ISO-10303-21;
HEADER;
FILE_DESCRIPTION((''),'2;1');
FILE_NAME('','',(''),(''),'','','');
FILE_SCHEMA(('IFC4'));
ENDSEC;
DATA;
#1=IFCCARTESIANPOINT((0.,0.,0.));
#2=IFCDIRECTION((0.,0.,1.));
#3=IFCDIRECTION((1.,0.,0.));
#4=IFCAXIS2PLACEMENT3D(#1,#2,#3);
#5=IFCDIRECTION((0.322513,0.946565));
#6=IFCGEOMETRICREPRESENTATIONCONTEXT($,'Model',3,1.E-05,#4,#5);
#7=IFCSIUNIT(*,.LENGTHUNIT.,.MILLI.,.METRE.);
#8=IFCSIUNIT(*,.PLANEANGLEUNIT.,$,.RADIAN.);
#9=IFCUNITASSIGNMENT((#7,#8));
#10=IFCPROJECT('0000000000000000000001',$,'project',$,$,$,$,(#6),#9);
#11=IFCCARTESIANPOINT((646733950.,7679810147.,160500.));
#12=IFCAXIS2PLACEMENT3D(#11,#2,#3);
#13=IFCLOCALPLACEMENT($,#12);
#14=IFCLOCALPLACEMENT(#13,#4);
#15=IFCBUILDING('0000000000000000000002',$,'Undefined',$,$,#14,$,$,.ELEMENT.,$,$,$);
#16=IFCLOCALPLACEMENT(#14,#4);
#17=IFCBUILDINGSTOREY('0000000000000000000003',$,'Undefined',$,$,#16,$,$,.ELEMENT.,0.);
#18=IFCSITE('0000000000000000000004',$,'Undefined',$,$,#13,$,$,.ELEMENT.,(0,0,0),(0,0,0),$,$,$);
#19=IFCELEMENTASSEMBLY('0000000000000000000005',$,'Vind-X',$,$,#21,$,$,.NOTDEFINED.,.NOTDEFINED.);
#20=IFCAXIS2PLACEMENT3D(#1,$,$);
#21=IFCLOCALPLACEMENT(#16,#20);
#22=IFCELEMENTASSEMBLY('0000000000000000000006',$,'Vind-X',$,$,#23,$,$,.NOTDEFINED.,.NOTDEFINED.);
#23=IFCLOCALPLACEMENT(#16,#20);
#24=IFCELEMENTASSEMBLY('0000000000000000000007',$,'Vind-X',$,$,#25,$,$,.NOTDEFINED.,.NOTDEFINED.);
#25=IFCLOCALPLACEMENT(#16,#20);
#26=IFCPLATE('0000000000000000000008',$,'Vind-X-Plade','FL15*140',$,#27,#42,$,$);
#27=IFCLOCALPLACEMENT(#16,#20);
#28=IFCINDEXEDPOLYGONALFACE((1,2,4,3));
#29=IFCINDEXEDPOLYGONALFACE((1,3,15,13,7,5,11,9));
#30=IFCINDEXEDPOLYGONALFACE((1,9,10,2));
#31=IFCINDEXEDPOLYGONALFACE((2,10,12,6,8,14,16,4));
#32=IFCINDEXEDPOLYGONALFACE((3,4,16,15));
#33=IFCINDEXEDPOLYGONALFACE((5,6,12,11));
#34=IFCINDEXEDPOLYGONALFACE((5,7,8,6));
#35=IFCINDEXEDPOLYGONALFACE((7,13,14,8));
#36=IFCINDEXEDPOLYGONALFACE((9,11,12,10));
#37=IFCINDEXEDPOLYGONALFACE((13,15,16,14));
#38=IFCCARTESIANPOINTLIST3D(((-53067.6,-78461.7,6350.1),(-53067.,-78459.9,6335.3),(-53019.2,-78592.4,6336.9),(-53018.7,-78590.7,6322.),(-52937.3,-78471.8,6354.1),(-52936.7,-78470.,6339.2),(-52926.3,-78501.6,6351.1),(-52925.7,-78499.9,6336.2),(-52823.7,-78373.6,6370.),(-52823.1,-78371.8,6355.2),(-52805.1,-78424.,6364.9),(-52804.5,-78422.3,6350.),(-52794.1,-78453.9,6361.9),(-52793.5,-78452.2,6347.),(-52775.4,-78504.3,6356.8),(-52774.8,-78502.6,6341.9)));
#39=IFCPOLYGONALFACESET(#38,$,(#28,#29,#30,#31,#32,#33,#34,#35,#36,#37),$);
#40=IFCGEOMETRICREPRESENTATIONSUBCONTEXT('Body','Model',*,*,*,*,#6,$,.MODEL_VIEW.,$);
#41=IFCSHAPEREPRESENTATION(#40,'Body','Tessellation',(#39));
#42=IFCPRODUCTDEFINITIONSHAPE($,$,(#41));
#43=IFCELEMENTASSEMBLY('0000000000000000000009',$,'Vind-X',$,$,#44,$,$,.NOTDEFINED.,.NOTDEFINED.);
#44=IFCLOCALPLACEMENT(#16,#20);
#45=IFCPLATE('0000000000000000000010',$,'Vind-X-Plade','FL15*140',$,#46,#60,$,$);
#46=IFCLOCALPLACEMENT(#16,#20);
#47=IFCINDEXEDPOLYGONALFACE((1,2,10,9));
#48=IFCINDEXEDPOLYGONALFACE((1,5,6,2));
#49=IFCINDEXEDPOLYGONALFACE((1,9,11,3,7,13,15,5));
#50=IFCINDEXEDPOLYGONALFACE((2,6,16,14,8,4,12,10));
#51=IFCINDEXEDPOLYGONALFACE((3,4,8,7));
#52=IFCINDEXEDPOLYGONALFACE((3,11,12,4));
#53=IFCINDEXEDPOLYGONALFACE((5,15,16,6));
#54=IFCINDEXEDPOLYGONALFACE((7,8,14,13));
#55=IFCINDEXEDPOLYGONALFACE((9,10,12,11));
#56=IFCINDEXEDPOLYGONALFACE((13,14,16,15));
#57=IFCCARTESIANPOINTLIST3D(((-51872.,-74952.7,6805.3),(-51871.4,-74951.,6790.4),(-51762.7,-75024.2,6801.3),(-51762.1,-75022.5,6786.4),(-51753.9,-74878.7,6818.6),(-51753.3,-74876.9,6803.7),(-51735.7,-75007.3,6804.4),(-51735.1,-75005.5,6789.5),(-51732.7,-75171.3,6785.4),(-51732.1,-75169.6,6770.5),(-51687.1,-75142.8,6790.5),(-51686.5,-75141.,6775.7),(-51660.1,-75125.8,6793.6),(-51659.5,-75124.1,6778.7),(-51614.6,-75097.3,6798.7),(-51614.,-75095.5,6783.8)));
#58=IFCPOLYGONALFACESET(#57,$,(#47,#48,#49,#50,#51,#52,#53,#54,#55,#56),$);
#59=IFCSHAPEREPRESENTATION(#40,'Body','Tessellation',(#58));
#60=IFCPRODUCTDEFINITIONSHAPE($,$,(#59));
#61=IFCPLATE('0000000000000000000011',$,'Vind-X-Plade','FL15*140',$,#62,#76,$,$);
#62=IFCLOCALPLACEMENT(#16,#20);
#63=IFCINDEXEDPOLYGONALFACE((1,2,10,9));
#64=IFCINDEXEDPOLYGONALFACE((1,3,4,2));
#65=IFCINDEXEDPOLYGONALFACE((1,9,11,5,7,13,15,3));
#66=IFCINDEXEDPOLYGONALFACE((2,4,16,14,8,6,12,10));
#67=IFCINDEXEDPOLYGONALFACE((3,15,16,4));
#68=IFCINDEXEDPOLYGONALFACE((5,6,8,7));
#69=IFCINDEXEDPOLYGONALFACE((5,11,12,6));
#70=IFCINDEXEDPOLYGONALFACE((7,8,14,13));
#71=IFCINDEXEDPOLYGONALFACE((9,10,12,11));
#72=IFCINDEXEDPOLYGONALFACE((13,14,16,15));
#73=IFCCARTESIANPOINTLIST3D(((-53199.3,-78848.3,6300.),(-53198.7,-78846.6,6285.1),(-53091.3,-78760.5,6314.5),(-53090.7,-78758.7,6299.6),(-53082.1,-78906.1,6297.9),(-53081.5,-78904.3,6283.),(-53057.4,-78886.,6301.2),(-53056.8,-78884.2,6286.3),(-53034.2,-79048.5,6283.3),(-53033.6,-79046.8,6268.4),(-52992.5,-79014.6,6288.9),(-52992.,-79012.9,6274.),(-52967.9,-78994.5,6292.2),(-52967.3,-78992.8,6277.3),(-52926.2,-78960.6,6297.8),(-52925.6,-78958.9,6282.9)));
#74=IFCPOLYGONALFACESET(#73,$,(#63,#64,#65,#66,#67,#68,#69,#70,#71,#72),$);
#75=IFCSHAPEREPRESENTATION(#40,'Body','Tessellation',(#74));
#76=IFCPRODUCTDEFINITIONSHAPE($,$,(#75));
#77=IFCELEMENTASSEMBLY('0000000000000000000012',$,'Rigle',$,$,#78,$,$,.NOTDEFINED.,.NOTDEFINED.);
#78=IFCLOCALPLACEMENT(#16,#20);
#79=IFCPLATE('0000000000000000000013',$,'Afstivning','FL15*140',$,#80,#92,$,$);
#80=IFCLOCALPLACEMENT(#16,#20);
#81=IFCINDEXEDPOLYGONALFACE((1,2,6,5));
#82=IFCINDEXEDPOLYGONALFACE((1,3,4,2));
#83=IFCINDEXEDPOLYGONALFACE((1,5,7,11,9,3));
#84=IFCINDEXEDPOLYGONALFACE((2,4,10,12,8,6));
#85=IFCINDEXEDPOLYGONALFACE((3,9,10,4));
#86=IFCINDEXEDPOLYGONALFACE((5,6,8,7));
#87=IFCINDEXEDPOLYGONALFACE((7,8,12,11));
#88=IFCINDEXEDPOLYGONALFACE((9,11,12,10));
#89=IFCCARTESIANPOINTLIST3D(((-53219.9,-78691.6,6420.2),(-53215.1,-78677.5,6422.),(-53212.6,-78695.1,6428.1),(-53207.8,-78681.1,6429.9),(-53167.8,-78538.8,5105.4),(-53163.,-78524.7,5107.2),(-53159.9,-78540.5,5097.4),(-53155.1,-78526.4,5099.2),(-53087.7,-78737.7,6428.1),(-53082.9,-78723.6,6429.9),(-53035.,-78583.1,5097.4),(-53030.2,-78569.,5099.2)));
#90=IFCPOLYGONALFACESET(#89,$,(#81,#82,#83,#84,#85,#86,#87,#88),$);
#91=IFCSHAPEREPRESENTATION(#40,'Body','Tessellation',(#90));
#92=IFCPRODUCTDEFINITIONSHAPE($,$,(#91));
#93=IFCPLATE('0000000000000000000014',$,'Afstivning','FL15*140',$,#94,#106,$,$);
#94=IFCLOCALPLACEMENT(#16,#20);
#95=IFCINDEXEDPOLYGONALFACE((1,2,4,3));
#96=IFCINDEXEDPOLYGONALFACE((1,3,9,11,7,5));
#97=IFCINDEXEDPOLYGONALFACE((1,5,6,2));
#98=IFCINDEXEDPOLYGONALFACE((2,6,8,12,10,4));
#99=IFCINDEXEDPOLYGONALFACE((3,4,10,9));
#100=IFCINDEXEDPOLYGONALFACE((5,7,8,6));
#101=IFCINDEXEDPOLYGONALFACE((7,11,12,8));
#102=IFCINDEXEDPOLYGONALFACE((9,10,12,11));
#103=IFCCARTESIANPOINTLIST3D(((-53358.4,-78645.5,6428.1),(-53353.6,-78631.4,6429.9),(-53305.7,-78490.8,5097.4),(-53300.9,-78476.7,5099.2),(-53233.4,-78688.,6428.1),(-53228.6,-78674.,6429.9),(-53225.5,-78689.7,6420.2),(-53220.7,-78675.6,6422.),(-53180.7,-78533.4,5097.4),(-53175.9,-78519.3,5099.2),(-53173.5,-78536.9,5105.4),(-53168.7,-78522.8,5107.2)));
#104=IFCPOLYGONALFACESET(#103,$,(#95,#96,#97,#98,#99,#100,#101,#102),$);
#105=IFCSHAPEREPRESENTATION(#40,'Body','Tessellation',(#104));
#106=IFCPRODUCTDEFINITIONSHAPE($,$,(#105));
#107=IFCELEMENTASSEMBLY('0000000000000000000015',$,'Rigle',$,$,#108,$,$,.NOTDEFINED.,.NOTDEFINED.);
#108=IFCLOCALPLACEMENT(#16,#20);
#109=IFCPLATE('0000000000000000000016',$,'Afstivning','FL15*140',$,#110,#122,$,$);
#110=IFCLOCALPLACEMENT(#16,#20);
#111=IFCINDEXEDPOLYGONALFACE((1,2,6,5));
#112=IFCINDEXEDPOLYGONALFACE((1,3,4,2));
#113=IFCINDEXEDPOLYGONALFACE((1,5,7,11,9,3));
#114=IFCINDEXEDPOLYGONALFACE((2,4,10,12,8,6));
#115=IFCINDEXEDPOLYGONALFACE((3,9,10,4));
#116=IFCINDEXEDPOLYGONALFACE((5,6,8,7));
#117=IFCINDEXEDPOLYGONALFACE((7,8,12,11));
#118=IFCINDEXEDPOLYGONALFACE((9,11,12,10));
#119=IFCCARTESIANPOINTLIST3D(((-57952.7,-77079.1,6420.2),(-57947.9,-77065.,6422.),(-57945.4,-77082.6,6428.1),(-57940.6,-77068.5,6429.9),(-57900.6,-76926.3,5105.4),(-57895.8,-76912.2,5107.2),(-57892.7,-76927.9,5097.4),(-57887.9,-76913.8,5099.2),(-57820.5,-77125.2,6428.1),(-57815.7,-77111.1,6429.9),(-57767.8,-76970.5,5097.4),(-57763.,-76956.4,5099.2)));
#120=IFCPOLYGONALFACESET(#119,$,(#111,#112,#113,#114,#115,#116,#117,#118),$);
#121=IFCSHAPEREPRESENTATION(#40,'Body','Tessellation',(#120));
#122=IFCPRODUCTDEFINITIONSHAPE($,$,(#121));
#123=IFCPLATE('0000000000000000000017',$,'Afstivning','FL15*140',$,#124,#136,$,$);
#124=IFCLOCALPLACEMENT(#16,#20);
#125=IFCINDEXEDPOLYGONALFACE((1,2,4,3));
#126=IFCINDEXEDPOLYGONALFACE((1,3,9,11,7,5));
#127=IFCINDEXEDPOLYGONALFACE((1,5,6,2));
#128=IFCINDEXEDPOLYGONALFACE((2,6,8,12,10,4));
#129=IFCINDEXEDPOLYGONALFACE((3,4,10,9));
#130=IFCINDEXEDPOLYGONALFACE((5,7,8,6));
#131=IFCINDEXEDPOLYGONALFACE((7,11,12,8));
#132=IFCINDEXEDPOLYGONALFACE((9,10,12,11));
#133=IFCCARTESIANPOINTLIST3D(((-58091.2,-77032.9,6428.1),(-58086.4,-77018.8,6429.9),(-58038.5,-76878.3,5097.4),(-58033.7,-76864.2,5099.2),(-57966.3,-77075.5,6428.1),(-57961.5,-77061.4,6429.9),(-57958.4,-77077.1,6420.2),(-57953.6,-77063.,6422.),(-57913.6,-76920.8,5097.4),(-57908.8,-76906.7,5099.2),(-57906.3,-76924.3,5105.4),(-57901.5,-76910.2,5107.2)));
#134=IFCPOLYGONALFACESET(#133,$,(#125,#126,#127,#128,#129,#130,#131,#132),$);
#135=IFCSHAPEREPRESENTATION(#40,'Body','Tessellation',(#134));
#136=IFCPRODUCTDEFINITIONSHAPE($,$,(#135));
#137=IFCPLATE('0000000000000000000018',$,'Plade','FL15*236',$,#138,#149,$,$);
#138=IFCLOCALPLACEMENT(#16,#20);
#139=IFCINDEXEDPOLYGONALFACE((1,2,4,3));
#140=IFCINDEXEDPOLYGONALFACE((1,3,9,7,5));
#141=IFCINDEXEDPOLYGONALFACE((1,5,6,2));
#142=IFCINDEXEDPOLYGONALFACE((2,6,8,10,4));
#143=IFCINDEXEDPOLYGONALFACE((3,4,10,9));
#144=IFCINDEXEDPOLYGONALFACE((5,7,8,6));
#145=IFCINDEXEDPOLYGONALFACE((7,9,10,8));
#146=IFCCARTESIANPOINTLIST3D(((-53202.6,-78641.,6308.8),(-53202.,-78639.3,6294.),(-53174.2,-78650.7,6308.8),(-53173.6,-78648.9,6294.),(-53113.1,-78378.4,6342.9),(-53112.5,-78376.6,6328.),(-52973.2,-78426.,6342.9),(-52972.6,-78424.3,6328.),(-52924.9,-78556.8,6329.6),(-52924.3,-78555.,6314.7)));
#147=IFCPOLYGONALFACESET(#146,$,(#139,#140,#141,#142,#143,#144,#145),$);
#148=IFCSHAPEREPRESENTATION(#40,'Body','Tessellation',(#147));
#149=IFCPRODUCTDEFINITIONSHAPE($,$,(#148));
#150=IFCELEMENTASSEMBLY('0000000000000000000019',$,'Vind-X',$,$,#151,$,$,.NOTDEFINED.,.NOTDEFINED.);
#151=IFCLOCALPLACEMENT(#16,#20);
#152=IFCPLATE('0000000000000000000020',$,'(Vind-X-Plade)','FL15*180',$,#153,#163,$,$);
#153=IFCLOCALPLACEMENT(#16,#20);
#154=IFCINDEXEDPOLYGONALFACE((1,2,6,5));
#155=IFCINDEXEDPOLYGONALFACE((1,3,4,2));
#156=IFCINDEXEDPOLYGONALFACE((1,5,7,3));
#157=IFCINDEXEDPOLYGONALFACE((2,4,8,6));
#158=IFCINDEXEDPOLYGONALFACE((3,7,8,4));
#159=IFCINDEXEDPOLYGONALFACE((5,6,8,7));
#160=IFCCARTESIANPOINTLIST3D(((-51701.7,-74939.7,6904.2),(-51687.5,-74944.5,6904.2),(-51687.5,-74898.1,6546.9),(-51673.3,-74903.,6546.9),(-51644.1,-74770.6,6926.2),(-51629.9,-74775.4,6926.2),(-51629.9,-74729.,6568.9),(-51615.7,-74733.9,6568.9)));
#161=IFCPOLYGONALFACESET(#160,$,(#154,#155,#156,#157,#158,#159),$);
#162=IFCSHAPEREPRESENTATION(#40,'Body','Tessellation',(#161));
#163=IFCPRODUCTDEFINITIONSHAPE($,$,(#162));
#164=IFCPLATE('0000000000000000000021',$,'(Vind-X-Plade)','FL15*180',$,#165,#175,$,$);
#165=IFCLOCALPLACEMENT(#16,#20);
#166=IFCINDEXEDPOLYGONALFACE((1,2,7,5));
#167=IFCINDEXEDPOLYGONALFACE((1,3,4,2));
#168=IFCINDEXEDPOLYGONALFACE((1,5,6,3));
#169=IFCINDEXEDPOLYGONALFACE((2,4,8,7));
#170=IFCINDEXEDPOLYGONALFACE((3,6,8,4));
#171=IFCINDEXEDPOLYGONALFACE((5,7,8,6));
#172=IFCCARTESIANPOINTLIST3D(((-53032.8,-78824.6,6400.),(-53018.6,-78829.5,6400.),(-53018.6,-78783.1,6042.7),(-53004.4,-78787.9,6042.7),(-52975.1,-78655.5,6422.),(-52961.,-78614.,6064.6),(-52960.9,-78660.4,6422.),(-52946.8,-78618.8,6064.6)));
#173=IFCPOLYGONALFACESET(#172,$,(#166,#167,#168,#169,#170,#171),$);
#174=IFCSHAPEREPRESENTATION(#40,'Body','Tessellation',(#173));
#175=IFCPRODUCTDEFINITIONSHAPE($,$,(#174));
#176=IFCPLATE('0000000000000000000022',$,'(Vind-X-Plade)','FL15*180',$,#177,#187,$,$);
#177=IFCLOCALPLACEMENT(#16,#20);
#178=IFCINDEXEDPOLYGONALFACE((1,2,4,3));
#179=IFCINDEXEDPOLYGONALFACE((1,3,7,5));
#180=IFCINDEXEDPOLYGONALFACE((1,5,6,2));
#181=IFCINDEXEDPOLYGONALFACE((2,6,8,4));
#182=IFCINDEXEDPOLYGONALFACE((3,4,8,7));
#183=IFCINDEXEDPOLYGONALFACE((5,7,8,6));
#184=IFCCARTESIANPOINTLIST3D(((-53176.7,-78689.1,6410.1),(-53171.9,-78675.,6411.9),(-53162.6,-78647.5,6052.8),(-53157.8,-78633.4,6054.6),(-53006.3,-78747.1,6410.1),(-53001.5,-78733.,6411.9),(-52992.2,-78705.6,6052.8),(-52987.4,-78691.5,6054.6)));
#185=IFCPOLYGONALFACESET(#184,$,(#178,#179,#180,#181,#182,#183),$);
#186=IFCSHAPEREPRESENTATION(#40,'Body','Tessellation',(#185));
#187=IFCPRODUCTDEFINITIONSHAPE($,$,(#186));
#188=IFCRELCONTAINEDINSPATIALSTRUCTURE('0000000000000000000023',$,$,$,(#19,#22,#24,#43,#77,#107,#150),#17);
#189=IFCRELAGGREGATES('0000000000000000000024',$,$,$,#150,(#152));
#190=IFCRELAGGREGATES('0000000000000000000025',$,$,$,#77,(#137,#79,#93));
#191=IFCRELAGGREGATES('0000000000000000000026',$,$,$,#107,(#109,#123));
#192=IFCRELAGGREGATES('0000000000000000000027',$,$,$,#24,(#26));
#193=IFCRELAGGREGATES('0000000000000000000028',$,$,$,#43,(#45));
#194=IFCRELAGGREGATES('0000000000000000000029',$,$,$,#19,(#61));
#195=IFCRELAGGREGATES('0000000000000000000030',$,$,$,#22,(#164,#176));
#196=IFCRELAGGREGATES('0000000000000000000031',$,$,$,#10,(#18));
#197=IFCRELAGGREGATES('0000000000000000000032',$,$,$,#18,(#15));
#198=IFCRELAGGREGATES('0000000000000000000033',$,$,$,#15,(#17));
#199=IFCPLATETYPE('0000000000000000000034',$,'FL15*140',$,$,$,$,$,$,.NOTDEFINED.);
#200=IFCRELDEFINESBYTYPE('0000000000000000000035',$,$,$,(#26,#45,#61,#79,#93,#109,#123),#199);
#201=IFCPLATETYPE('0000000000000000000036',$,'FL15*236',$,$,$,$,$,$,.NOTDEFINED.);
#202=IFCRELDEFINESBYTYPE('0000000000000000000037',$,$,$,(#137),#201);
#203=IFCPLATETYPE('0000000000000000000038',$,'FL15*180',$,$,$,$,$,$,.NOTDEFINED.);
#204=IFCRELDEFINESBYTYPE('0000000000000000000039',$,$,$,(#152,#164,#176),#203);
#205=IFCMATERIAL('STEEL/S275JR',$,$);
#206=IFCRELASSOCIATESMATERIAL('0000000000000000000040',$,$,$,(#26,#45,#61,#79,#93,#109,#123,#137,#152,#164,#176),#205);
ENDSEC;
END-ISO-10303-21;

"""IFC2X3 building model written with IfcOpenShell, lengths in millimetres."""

from ifc_helpers import new_model, si_unit, direction, frame, origin_with_axes, place, context, subcontext, project, spatial, polyline, outline, extrude, material, type_object, element, aggregate, save


model = new_model("IFC2X3")

# Units and contexts
model_context = context("Model", 3, precision=1e-05, world=origin_with_axes(), true_north=direction((0.322513, 0.946565)))
body_context = subcontext(model_context, "Body", "Model", "MODEL_VIEW")
ifc_project = project(units=[si_unit("LENGTHUNIT", "METRE", prefix="MILLI"), si_unit("PLANEANGLEUNIT", "RADIAN")], contexts=[model_context])

# Site, building, storey
site_placement = place(None, frame((646733950.0, 7679810147.0, 160500.0), z_axis=(0.0, 0.0, 1.0), x_axis=(1.0, 0.0, 0.0)))
site = spatial("IfcSite", under=ifc_project, at=site_placement, Name="Undefined", CompositionType="ELEMENT", RefLatitude=(0, 0, 0), RefLongitude=(0, 0, 0))
building_placement = place(site_placement, origin_with_axes())
building = spatial("IfcBuilding", under=site, at=building_placement, Name="Undefined", CompositionType="ELEMENT")
storey_placement = place(building_placement, origin_with_axes())
storey = spatial("IfcBuildingStorey", under=building, at=storey_placement, Name="Undefined", CompositionType="ELEMENT", Elevation=0.0)

# Element assembly
assembly_1_placement = place(storey_placement, origin_with_axes())
assembly_1 = element("IfcElementAssembly", 1, at=assembly_1_placement, inside=storey, Name="Vind-X", AssemblyPlace="NOTDEFINED", PredefinedType="NOTDEFINED")

# Element assembly
assembly_2_placement = place(storey_placement, origin_with_axes())
assembly_2 = element("IfcElementAssembly", 2, at=assembly_2_placement, inside=storey, Name="Vind-X", AssemblyPlace="NOTDEFINED", PredefinedType="NOTDEFINED")

# Element assemblies, plates
assembly_3_placement = place(storey_placement, origin_with_axes())
assembly_3 = element("IfcElementAssembly", 3, at=assembly_3_placement, inside=storey, Name="Vind-X", AssemblyPlace="NOTDEFINED", PredefinedType="NOTDEFINED")
ifc_material_1 = material(Name="STEEL/S275JR")
plate_type_1 = type_object("IfcPlateType", Name="FL15*140", PredefinedType="NOTDEFINED")
plate_1_placement = place(assembly_3_placement, frame((-52823.4, -78372.7, 6362.6), z_axis=(-0.039304, -0.115357, 0.992546), x_axis=(-0.937758, -0.338759, -0.076507)))
plate_1 = element("IfcPlate", 4, at=plate_1_placement, type_object=plate_type_1, material=ifc_material_1, Name="Vind-X-Plade", Description="FL15*140", context=body_context, shape_type="SweptSolid", body=[
    extrude(outline(polyline([(0.0, 0.0), (260.0, 0.0), (260.0, 140.0), (0.0, 140.0), (0.0, 86.0), (141.0, 86.0), (141.0, 54.0), (0.0, 54.0), (0.0, 0.0)])), frame((0.0, 0.0, -7.5), z_axis=(0.0, 0.0, 1.0), x_axis=(1.0, 0.0, 0.0)), (0.0, 0.0, 1.0), 15.0),
])
assembly_4_placement = place(storey_placement, origin_with_axes())
assembly_4 = element("IfcElementAssembly", 5, at=assembly_4_placement, inside=storey, Name="Vind-X", AssemblyPlace="NOTDEFINED", PredefinedType="NOTDEFINED")
plate_2_placement = place(assembly_4_placement, frame((-51614.3, -75096.4, 6791.3), z_axis=(-0.039304, -0.115357, 0.992546), x_axis=(-0.535845, 0.840843, 0.076507)))
plate_2 = element("IfcPlate", 6, at=plate_2_placement, type_object=plate_type_1, material=ifc_material_1, Name="Vind-X-Plade", Description="FL15*140", context=body_context, shape_type="SweptSolid", body=[
    extrude(outline(polyline([(0.0, 0.0), (260.0, 0.0), (260.0, 140.0), (0.0, 140.0), (0.0, 86.0), (141.0, 86.0), (141.0, 54.0), (0.0, 54.0), (0.0, 0.0)])), frame((0.0, 0.0, -7.5), z_axis=(0.0, 0.0, 1.0), x_axis=(1.0, 0.0, 0.0)), (0.0, 0.0, 1.0), 15.0),
])

# Plate
plate_3_placement = place(assembly_1_placement, frame((-52925.9, -78959.8, 6290.3), z_axis=(-0.039304, -0.115357, 0.992546), x_axis=(-0.634983, 0.769843, 0.064329)))
plate_3 = element("IfcPlate", 7, at=plate_3_placement, type_object=plate_type_1, material=ifc_material_1, Name="Vind-X-Plade", Description="FL15*140", context=body_context, shape_type="SweptSolid", body=[
    extrude(outline(polyline([(0.0, 0.0), (260.0, 0.0), (260.0, 140.0), (0.0, 140.0), (0.0, 86.0), (141.0, 86.0), (141.0, 54.0), (0.0, 54.0), (0.0, 0.0)])), frame((0.0, 0.0, -7.5), z_axis=(0.0, 0.0, 1.0), x_axis=(1.0, 0.0, 0.0)), (0.0, 0.0, 1.0), 15.0),
])

# Element assemblies, plates
assembly_5_placement = place(storey_placement, origin_with_axes())
assembly_5 = element("IfcElementAssembly", 8, at=assembly_5_placement, inside=storey, Name="Rigle", AssemblyPlace="NOTDEFINED", PredefinedType="NOTDEFINED")
plate_4_placement = place(assembly_5_placement, frame((-53032.6, -78576.0, 5098.3), z_axis=(0.320109, 0.93951, 0.121869), x_axis=(-0.946565, 0.322513, 0.0)))
plate_4 = element("IfcPlate", 9, at=plate_4_placement, type_object=plate_type_1, material=ifc_material_1, Name="Afstivning", Description="FL15*140", context=body_context, shape_type="SweptSolid", body=[
    extrude(outline(polyline([(0.0, 0.0), (132.0, 0.0), (140.0, 8.0), (140.0, 1332.7), (132.0, 1340.7), (0.0, 1340.7), (0.0, 0.0)])), frame((0.0, 0.0, -7.5), z_axis=(0.0, 0.0, 1.0), x_axis=(1.0, 0.0, 0.0)), (0.0, 0.0, 1.0), 15.0),
])
plate_5_placement = place(assembly_5_placement, frame((-53170.8, -78528.9, 5098.3), z_axis=(0.320109, 0.93951, 0.121869), x_axis=(-0.946565, 0.322513, 0.0)))
plate_5 = element("IfcPlate", 10, at=plate_5_placement, type_object=plate_type_1, material=ifc_material_1, Name="Afstivning", Description="FL15*140", context=body_context, shape_type="SweptSolid", body=[
    extrude(outline(polyline([(0.0, 8.0), (8.0, 0.0), (140.0, 0.0), (140.0, 1340.7), (8.0, 1340.7), (0.0, 1332.7), (0.0, 8.0)])), frame((0.0, 0.0, -7.5), z_axis=(0.0, 0.0, 1.0), x_axis=(1.0, 0.0, 0.0)), (0.0, 0.0, 1.0), 15.0),
])
assembly_6_placement = place(storey_placement, origin_with_axes())
assembly_6 = element("IfcElementAssembly", 11, at=assembly_6_placement, inside=storey, Name="Rigle", AssemblyPlace="NOTDEFINED", PredefinedType="NOTDEFINED")
plate_6_placement = place(assembly_6_placement, frame((-57765.4, -76963.5, 5098.3), z_axis=(0.320109, 0.93951, 0.121869), x_axis=(-0.946565, 0.322513, 0.0)))
plate_6 = element("IfcPlate", 12, at=plate_6_placement, type_object=plate_type_1, material=ifc_material_1, Name="Afstivning", Description="FL15*140", context=body_context, shape_type="SweptSolid", body=[
    extrude(outline(polyline([(0.0, 0.0), (132.0, 0.0), (140.0, 8.0), (140.0, 1332.7), (132.0, 1340.7), (0.0, 1340.7), (0.0, 0.0)])), frame((0.0, 0.0, -7.5), z_axis=(0.0, 0.0, 1.0), x_axis=(1.0, 0.0, 0.0)), (0.0, 0.0, 1.0), 15.0),
])
plate_7_placement = place(assembly_6_placement, frame((-57903.6, -76916.4, 5098.3), z_axis=(0.320109, 0.93951, 0.121869), x_axis=(-0.946565, 0.322513, 0.0)))
plate_7 = element("IfcPlate", 13, at=plate_7_placement, type_object=plate_type_1, material=ifc_material_1, Name="Afstivning", Description="FL15*140", context=body_context, shape_type="SweptSolid", body=[
    extrude(outline(polyline([(0.0, 8.0), (8.0, 0.0), (140.0, 0.0), (140.0, 1340.7), (8.0, 1340.7), (0.0, 1332.7), (0.0, 8.0)])), frame((0.0, 0.0, -7.5), z_axis=(0.0, 0.0, 1.0), x_axis=(1.0, 0.0, 0.0)), (0.0, 0.0, 1.0), 15.0),
])

# Plate
plate_type_2 = type_object("IfcPlateType", Name="FL15*236", PredefinedType="NOTDEFINED")
plate_8_placement = place(assembly_5_placement, frame((-53112.8, -78377.5, 6335.5), z_axis=(-0.039304, -0.115357, 0.992546), x_axis=(-0.320109, -0.93951, -0.121869)))
plate_8 = element("IfcPlate", 14, at=plate_8_placement, type_object=plate_type_2, material=ifc_material_1, Name="Plade", Description="FL15*236", context=body_context, shape_type="SweptSolid", body=[
    extrude(outline(polyline([(0.0, 0.0), (279.5, 0.0), (279.5, 30.0), (109.0, 235.7), (0.0, 147.8), (0.0, 0.0)])), frame((0.0, 0.0, -7.5), z_axis=(0.0, 0.0, 1.0), x_axis=(1.0, 0.0, 0.0)), (0.0, 0.0, 1.0), 15.0),
])

# Element assembly, plate
assembly_7_placement = place(storey_placement, origin_with_axes())
assembly_7 = element("IfcElementAssembly", 15, at=assembly_7_placement, inside=storey, Name="Vind-X", AssemblyPlace="NOTDEFINED", PredefinedType="NOTDEFINED")
plate_type_3 = type_object("IfcPlateType", Name="FL15*180", PredefinedType="NOTDEFINED")
plate_9_placement = place(assembly_7_placement, frame((-51694.6, -74942.1, 6904.2), z_axis=(-0.946565, 0.322513, 0.0), x_axis=(0.320109, 0.93951, 0.121869)))
plate_9 = element("IfcPlate", 16, at=plate_9_placement, type_object=plate_type_3, material=ifc_material_1, Name="(Vind-X-Plade)", Description="FL15*180", context=body_context, shape_type="SweptSolid", body=[
    extrude(outline(polyline([(0.0, 0.0), (180.0, 0.0), (180.0, 360.0), (0.0, 360.0), (0.0, 0.0)])), frame((0.0, 0.0, -7.5), z_axis=(0.0, 0.0, 1.0), x_axis=(1.0, 0.0, 0.0)), (0.0, 0.0, 1.0), 15.0),
])
aggregate(assembly_7, [plate_9])

# Plates
plate_10_placement = place(assembly_2_placement, frame((-53025.7, -78827.0, 6400.0), z_axis=(-0.946565, 0.322513, 0.0), x_axis=(0.320109, 0.93951, 0.121869)))
plate_10 = element("IfcPlate", 17, at=plate_10_placement, type_object=plate_type_3, material=ifc_material_1, Name="(Vind-X-Plade)", Description="FL15*180", context=body_context, shape_type="SweptSolid", body=[
    extrude(outline(polyline([(0.0, 0.0), (180.0, 0.0), (180.0, 360.0), (0.0, 360.0), (0.0, 0.0)])), frame((0.0, 0.0, -7.5), z_axis=(0.0, 0.0, 1.0), x_axis=(1.0, 0.0, 0.0)), (0.0, 0.0, 1.0), 15.0),
])
plate_11_placement = place(assembly_2_placement, frame((-53160.2, -78640.5, 6053.7), z_axis=(0.320109, 0.93951, 0.121869), x_axis=(-0.039304, -0.115357, 0.992546)))
plate_11 = element("IfcPlate", 18, at=plate_11_placement, type_object=plate_type_3, material=ifc_material_1, Name="(Vind-X-Plade)", Description="FL15*180", context=body_context, shape_type="SweptSolid", body=[
    extrude(outline(polyline([(0.0, 0.0), (360.0, 0.0), (360.0, 180.0), (0.0, 180.0), (0.0, 0.0)])), frame((0.0, 0.0, -7.5), z_axis=(0.0, 0.0, 1.0), x_axis=(1.0, 0.0, 0.0)), (0.0, 0.0, 1.0), 15.0),
])

aggregate(assembly_5, [plate_8, plate_4, plate_5])
aggregate(assembly_6, [plate_6, plate_7])

aggregate(assembly_3, [plate_1])
aggregate(assembly_4, [plate_2])
aggregate(assembly_1, [plate_3])

aggregate(assembly_2, [plate_10, plate_11])

save(model, "model.ifc")
